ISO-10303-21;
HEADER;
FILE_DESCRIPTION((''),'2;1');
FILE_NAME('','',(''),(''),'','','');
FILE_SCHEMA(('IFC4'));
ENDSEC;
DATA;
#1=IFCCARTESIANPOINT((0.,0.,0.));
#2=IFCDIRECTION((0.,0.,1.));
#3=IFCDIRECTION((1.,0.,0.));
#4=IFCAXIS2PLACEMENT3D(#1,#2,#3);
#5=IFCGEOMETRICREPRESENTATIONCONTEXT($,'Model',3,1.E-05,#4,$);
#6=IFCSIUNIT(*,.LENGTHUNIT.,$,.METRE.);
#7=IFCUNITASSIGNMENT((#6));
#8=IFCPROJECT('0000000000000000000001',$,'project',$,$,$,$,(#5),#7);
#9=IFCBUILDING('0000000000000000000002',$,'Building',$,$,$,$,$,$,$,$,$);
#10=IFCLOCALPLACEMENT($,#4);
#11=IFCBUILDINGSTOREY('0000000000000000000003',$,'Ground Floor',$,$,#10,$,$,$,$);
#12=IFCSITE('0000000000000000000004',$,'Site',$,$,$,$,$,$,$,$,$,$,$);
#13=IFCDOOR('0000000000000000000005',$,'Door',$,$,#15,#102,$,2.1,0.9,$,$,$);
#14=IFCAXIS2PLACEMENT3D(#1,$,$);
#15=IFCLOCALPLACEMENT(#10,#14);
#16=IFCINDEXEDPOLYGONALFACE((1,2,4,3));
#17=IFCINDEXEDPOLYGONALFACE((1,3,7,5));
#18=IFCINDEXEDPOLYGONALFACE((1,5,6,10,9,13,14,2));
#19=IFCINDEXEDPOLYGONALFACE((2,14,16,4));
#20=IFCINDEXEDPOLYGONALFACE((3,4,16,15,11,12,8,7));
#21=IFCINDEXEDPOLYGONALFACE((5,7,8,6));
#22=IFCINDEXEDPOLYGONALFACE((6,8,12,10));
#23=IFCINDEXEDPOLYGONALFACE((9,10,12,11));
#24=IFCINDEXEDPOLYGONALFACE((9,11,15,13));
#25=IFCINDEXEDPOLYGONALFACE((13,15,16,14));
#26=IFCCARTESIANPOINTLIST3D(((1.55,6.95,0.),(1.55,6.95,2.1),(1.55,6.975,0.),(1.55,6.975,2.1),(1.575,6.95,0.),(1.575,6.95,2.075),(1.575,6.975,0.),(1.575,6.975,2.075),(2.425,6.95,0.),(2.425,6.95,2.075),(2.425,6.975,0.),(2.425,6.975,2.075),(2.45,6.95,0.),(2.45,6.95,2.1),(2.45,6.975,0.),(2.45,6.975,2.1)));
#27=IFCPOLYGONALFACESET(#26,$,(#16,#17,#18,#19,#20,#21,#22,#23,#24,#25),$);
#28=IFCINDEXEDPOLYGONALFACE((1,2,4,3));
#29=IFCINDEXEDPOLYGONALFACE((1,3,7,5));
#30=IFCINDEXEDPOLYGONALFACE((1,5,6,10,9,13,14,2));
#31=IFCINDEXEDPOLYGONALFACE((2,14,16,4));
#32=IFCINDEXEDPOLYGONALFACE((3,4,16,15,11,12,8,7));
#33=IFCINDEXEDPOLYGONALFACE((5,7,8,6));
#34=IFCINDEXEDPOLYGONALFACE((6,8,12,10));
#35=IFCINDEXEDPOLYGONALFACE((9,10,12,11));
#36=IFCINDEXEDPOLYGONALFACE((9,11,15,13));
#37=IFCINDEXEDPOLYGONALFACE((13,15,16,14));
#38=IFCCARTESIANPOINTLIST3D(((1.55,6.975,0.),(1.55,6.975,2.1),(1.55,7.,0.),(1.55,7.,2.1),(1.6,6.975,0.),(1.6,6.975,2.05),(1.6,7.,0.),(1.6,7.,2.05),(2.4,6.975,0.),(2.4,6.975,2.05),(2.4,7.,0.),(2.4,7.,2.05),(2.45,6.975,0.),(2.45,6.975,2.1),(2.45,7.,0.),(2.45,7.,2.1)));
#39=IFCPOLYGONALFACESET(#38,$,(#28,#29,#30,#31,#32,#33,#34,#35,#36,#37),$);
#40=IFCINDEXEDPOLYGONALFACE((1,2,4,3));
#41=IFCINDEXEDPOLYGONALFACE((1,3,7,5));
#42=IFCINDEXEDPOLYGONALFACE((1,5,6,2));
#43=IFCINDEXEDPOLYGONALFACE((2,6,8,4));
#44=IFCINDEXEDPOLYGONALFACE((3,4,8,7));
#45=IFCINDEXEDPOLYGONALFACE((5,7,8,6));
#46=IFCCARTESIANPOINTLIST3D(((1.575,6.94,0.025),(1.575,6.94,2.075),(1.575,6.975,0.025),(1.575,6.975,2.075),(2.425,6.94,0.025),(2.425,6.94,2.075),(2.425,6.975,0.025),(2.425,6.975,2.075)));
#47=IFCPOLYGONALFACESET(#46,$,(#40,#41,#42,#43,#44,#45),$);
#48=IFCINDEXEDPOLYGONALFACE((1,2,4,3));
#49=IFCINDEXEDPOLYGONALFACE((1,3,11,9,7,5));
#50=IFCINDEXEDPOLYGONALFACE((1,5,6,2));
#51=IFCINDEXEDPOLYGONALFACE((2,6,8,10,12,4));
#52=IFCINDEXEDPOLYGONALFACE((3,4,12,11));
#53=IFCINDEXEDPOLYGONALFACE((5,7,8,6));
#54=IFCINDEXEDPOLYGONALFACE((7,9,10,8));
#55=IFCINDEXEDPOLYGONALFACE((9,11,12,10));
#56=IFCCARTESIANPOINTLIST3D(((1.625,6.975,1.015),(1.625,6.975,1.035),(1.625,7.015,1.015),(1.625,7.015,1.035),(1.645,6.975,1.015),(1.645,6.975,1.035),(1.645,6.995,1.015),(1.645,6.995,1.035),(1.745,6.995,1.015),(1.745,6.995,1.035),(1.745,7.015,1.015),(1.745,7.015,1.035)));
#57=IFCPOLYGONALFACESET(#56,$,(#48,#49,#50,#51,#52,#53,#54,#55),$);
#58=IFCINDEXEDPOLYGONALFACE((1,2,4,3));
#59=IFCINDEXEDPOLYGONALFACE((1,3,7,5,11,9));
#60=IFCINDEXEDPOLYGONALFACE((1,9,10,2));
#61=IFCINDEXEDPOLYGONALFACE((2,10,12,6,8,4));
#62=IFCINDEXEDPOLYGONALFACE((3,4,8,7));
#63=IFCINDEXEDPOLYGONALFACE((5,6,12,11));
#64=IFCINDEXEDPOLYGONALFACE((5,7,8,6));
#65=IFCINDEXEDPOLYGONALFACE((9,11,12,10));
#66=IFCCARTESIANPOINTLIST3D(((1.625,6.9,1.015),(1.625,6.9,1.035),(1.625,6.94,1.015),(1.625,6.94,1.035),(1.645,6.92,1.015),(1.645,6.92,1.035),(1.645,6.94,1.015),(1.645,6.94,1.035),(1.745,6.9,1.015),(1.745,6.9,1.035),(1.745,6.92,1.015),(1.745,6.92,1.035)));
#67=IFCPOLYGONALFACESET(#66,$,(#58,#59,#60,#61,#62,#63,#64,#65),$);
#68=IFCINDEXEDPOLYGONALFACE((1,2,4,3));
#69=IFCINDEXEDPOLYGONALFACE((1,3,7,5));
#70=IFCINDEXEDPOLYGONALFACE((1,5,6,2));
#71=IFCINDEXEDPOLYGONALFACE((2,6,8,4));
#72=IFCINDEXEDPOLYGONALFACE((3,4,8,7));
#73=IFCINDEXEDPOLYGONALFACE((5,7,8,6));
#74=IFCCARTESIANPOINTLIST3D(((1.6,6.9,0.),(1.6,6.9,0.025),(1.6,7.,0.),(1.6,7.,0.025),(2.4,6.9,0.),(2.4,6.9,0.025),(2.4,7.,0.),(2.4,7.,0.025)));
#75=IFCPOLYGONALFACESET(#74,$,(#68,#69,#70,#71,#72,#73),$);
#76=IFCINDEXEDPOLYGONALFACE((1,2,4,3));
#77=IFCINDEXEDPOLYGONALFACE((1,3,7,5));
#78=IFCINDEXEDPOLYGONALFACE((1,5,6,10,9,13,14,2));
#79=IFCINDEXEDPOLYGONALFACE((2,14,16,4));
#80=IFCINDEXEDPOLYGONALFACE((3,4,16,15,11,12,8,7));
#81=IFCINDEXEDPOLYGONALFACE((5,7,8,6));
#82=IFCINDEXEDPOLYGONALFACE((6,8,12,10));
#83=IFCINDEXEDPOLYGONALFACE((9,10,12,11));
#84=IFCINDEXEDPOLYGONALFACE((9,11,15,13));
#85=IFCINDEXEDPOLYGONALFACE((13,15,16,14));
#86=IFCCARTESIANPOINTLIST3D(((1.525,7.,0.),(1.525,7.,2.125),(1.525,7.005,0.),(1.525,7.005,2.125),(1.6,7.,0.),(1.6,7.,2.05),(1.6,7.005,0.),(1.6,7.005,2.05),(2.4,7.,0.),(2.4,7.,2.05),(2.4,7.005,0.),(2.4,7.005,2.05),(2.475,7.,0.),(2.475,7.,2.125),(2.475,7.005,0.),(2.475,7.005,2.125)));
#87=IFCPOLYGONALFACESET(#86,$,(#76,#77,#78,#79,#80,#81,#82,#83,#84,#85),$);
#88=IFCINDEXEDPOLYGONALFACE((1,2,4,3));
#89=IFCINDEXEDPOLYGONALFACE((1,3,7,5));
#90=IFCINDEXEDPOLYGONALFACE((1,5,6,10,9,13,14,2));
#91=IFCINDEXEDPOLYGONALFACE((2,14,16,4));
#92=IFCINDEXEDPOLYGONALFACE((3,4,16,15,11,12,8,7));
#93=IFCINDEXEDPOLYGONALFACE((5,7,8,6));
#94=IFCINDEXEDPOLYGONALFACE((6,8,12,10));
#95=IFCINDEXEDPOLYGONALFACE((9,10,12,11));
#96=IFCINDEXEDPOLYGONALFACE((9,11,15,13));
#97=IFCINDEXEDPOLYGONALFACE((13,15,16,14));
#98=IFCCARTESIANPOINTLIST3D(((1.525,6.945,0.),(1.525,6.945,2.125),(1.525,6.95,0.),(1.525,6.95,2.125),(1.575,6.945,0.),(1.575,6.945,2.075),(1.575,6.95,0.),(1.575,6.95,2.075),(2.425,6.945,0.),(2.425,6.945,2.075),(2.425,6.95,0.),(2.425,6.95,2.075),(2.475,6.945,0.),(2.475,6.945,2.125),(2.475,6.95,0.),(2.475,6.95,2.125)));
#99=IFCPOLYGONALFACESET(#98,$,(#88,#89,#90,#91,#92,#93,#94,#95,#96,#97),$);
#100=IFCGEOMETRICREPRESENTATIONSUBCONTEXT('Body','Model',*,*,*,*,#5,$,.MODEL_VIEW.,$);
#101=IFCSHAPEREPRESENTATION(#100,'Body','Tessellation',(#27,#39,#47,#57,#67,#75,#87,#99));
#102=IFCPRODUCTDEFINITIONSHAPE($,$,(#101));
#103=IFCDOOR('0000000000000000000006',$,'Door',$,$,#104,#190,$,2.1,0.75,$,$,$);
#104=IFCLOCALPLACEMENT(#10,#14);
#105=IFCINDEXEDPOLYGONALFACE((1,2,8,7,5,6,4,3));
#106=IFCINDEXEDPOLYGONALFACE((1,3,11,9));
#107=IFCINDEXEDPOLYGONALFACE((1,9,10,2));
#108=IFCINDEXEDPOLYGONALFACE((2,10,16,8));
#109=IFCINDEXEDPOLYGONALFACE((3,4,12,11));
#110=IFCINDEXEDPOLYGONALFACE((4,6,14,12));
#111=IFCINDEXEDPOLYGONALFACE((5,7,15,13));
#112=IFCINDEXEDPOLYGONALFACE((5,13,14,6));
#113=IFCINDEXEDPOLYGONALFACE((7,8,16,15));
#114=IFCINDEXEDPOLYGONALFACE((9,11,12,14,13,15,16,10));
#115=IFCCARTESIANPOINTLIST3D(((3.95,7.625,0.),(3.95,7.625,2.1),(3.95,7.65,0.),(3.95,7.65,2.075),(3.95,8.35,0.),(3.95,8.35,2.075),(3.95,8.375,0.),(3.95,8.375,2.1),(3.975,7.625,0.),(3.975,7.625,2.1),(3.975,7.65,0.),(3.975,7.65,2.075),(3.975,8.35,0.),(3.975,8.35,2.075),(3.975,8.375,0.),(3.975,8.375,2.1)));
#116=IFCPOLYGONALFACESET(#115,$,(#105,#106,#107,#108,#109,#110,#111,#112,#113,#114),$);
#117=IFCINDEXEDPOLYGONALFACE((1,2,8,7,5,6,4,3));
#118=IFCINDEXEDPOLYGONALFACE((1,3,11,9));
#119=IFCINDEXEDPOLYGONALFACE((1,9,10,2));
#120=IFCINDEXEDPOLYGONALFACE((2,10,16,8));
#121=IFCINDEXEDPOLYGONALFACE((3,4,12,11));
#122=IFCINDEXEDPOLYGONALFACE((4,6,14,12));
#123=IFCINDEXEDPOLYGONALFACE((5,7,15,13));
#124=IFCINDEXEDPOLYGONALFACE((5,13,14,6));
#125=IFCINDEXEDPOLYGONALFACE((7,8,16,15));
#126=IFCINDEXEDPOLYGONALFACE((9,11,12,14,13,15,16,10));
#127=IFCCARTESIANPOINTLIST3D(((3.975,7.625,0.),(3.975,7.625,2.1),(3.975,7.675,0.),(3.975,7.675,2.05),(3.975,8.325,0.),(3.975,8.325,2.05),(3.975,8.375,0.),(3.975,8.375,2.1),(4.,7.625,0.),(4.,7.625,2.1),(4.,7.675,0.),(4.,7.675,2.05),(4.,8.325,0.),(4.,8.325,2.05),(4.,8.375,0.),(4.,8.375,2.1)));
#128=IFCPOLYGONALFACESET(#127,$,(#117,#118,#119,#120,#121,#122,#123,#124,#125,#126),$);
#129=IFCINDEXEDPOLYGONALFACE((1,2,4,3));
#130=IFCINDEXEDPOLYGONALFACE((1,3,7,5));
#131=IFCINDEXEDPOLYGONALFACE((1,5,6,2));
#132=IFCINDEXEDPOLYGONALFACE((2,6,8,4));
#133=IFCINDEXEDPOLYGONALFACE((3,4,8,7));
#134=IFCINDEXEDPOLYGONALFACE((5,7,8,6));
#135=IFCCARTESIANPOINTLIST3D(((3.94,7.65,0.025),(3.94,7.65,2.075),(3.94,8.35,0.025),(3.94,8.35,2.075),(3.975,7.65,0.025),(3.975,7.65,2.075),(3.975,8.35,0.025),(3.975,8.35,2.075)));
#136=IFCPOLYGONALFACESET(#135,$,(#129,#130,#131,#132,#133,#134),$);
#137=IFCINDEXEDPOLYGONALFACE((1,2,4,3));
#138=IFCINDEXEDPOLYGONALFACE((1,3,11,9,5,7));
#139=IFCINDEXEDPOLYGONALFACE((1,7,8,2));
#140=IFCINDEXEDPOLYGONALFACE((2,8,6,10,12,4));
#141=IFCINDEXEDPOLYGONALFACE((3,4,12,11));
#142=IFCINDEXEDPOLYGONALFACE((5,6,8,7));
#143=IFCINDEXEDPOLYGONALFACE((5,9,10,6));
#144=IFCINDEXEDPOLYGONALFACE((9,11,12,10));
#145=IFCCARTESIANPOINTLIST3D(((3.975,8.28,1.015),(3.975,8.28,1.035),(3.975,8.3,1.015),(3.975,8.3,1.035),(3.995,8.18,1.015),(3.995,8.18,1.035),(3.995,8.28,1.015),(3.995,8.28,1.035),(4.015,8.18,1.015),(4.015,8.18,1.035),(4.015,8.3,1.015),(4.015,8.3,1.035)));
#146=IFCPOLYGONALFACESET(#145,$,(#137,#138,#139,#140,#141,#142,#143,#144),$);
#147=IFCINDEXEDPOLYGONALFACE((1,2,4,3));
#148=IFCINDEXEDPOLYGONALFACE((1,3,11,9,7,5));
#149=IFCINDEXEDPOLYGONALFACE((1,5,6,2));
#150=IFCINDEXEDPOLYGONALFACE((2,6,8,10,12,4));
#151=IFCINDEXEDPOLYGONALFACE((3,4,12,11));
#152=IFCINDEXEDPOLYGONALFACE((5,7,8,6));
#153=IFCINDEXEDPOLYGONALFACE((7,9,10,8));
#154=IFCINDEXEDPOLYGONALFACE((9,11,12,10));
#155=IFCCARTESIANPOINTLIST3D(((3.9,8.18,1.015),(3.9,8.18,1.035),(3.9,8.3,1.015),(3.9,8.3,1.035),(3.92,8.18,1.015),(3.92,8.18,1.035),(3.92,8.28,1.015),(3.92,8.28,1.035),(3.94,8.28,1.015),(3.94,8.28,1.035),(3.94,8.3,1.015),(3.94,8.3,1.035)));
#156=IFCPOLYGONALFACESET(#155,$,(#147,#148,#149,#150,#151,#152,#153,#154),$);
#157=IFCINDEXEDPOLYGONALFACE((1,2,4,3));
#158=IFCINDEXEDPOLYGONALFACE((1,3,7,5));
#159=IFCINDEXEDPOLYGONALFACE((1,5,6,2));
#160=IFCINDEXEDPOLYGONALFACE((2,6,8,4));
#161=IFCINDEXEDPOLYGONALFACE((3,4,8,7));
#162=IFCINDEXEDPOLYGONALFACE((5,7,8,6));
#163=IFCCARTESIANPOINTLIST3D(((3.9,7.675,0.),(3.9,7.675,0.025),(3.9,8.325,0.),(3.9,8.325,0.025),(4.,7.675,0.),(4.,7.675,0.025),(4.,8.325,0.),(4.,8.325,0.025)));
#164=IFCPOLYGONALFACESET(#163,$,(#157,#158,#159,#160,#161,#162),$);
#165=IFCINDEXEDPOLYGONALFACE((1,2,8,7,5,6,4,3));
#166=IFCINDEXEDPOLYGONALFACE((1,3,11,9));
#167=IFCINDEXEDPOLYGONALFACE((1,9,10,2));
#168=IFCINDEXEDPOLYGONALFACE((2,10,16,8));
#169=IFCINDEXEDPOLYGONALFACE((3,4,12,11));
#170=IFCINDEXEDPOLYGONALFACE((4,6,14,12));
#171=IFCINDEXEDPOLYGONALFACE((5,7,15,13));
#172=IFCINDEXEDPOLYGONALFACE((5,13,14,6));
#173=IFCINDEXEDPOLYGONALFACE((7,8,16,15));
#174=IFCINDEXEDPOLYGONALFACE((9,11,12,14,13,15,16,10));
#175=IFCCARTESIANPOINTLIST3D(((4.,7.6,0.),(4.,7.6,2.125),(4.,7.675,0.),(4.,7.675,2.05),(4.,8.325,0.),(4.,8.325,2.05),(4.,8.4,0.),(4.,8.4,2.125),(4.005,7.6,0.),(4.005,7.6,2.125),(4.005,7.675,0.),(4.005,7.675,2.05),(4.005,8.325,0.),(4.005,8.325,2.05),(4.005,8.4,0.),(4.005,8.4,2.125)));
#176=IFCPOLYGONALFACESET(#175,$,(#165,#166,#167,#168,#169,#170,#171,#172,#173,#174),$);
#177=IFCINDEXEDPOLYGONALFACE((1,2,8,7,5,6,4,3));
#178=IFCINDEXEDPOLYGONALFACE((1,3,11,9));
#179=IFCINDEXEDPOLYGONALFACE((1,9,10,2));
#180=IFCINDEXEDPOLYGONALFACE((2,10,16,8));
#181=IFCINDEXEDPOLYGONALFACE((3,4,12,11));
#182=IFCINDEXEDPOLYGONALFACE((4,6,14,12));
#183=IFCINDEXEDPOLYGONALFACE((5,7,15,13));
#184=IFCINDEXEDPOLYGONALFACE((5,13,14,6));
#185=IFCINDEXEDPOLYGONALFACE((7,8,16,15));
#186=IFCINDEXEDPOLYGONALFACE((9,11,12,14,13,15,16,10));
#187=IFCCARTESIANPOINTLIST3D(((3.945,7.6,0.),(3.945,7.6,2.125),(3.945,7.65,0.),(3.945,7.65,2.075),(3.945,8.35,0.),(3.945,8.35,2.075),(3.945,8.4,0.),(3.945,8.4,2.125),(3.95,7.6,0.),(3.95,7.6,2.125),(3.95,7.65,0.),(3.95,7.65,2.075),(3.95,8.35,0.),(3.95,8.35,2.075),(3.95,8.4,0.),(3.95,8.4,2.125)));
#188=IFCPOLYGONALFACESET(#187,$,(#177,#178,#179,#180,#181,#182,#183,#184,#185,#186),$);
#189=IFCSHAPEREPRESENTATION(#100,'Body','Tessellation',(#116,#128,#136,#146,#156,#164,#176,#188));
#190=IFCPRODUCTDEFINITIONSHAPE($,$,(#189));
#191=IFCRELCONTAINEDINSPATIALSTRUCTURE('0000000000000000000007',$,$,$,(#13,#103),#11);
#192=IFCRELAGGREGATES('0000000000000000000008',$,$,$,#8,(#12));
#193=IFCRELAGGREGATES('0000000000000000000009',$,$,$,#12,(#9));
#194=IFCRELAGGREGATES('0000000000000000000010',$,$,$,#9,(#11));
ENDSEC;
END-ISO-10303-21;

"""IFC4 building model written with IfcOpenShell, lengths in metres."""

from ifc_helpers import new_model, si_unit, frame, origin_with_axes, place, context, subcontext, project, spatial, line, indexed_curve, outline, extrude, element, save


model = new_model("IFC4")

# Units and contexts
model_context = context("Model", 3, precision=1e-05, world=origin_with_axes())
body_context = subcontext(model_context, "Body", "Model", "MODEL_VIEW")
ifc_project = project(units=[si_unit("LENGTHUNIT", "METRE")], contexts=[model_context])

# Site, building, storey
site = spatial("IfcSite", under=ifc_project, Name="Site")
building = spatial("IfcBuilding", under=site, Name="Building")
storey_placement = place(None, origin_with_axes())
storey = spatial("IfcBuildingStorey", under=building, at=storey_placement, Name="Ground Floor")

# Doors
door_1_placement = place(storey_placement, frame((2.45, 7.0, 0.0), z_axis=(0.0, 0.0, 1.0), x_axis=(-1.0, 0.0, 0.0)))
element("IfcDoor", 1, at=door_1_placement, inside=storey, Name="Door", OverallHeight=2.1, OverallWidth=0.9, context=body_context, shape_type="SweptSolid", body=[
    extrude(outline(indexed_curve([(0.0, 0.0), (0.0, 2.1), (0.9, 2.1), (0.9, 0.0), (0.875, 0.0), (0.875, 2.075), (0.025, 2.075), (0.025, 0.0)], segments=[line(1, 2, 3, 4, 5, 6, 7, 8, 1)])), frame((0.0, 0.025, 0.0), z_axis=(0.0, -1.0, 0.0), x_axis=(1.0, 0.0, 0.0)), (0.0, 0.0, -1.0), 0.025),
    extrude(outline(indexed_curve([(0.0, 0.0), (0.0, 2.1), (0.9, 2.1), (0.9, 0.0), (0.85, 0.0), (0.85, 2.05), (0.05, 2.05), (0.05, 0.0)], segments=[line(1, 2, 3, 4, 5, 6, 7, 8, 1)])), frame((0.0, 0.0, 0.0), z_axis=(0.0, -1.0, 0.0), x_axis=(1.0, 0.0, 0.0)), (0.0, 0.0, -1.0), 0.025),
    extrude(outline(indexed_curve([(0.0, 0.0), (0.85, 0.0), (0.85, 0.035), (0.0, 0.035)], segments=[line(1, 2, 3, 4, 1)])), frame((0.025, 0.025, 0.025), z_axis=(0.0, 0.0, 1.0), x_axis=(1.0, 0.0, 0.0)), (0.0, 0.0, 1.0), 2.05),
    extrude(outline(indexed_curve([(0.0, 0.0), (0.0, -0.04), (-0.12, -0.04), (-0.12, -0.02), (-0.02, -0.02), (-0.02, 0.0)], segments=[line(1, 2, 3, 4, 5, 6, 1)])), frame((0.825, 0.025, 1.015), z_axis=(0.0, 0.0, 1.0), x_axis=(1.0, 0.0, 0.0)), (0.0, 0.0, 1.0), 0.02),
    extrude(outline(indexed_curve([(0.0, 0.0), (0.0, 0.04), (-0.12, 0.04), (-0.12, 0.02), (-0.02, 0.02), (-0.02, 0.0)], segments=[line(1, 2, 3, 4, 5, 6, 1)])), frame((0.825, 0.06, 1.015), z_axis=(0.0, 0.0, 1.0), x_axis=(1.0, 0.0, 0.0)), (0.0, 0.0, 1.0), 0.02),
    extrude(outline(indexed_curve([(0.0, 0.0), (0.8, 0.0), (0.8, 0.1), (0.0, 0.1)], segments=[line(1, 2, 3, 4, 1)])), frame((0.05, 0.0, 0.0), z_axis=(0.0, 0.0, 1.0), x_axis=(1.0, 0.0, 0.0)), (0.0, 0.0, 1.0), 0.025),
    extrude(outline(indexed_curve([(0.0, 0.0), (0.0, 2.125), (0.95, 2.125), (0.95, 0.0), (0.875, 0.0), (0.875, 2.05), (0.075, 2.05), (0.075, 0.0)], segments=[line(1, 2, 3, 4, 5, 6, 7, 8, 1)])), frame((-0.025, -0.005, 0.0), z_axis=(0.0, -1.0, 0.0), x_axis=(1.0, 0.0, 0.0)), (0.0, 0.0, -1.0), 0.005),
    extrude(outline(indexed_curve([(0.0, 0.0), (0.0, 2.125), (0.95, 2.125), (0.95, 0.0), (0.9, 0.0), (0.9, 2.075), (0.05, 2.075), (0.05, 0.0)], segments=[line(1, 2, 3, 4, 5, 6, 7, 8, 1)])), frame((-0.025, 0.05, 0.0), z_axis=(0.0, -1.0, 0.0), x_axis=(1.0, 0.0, 0.0)), (0.0, 0.0, -1.0), 0.005),
])
door_2_placement = place(storey_placement, frame((4.0, 7.625, 0.0), z_axis=(0.0, 0.0, 1.0), x_axis=(0.0, 1.0, 0.0)))
element("IfcDoor", 2, at=door_2_placement, inside=storey, Name="Door", OverallHeight=2.1, OverallWidth=0.75, context=body_context, shape_type="SweptSolid", body=[
    extrude(outline(indexed_curve([(0.0, 0.0), (0.0, 2.1), (0.75, 2.1), (0.75, 0.0), (0.725, 0.0), (0.725, 2.075), (0.025, 2.075), (0.025, 0.0)], segments=[line(1, 2, 3, 4, 5, 6, 7, 8, 1)])), frame((0.0, 0.025, 0.0), z_axis=(0.0, -1.0, 0.0), x_axis=(1.0, 0.0, 0.0)), (0.0, 0.0, -1.0), 0.025),
    extrude(outline(indexed_curve([(0.0, 0.0), (0.0, 2.1), (0.75, 2.1), (0.75, 0.0), (0.7, 0.0), (0.7, 2.05), (0.05, 2.05), (0.05, 0.0)], segments=[line(1, 2, 3, 4, 5, 6, 7, 8, 1)])), frame((0.0, 0.0, 0.0), z_axis=(0.0, -1.0, 0.0), x_axis=(1.0, 0.0, 0.0)), (0.0, 0.0, -1.0), 0.025),
    extrude(outline(indexed_curve([(0.0, 0.0), (0.7, 0.0), (0.7, 0.035), (0.0, 0.035)], segments=[line(1, 2, 3, 4, 1)])), frame((0.025, 0.025, 0.025), z_axis=(0.0, 0.0, 1.0), x_axis=(1.0, 0.0, 0.0)), (0.0, 0.0, 1.0), 2.05),
    extrude(outline(indexed_curve([(0.0, 0.0), (0.0, -0.04), (-0.12, -0.04), (-0.12, -0.02), (-0.02, -0.02), (-0.02, 0.0)], segments=[line(1, 2, 3, 4, 5, 6, 1)])), frame((0.675, 0.025, 1.015), z_axis=(0.0, 0.0, 1.0), x_axis=(1.0, 0.0, 0.0)), (0.0, 0.0, 1.0), 0.02),
    extrude(outline(indexed_curve([(0.0, 0.0), (0.0, 0.04), (-0.12, 0.04), (-0.12, 0.02), (-0.02, 0.02), (-0.02, 0.0)], segments=[line(1, 2, 3, 4, 5, 6, 1)])), frame((0.675, 0.06, 1.015), z_axis=(0.0, 0.0, 1.0), x_axis=(1.0, 0.0, 0.0)), (0.0, 0.0, 1.0), 0.02),
    extrude(outline(indexed_curve([(0.0, 0.0), (0.65, 0.0), (0.65, 0.1), (0.0, 0.1)], segments=[line(1, 2, 3, 4, 1)])), frame((0.05, 0.0, 0.0), z_axis=(0.0, 0.0, 1.0), x_axis=(1.0, 0.0, 0.0)), (0.0, 0.0, 1.0), 0.025),
    extrude(outline(indexed_curve([(0.0, 0.0), (0.0, 2.125), (0.8, 2.125), (0.8, 0.0), (0.725, 0.0), (0.725, 2.05), (0.075, 2.05), (0.075, 0.0)], segments=[line(1, 2, 3, 4, 5, 6, 7, 8, 1)])), frame((-0.025, -0.005, 0.0), z_axis=(0.0, -1.0, 0.0), x_axis=(1.0, 0.0, 0.0)), (0.0, 0.0, -1.0), 0.005),
    extrude(outline(indexed_curve([(0.0, 0.0), (0.0, 2.125), (0.8, 2.125), (0.8, 0.0), (0.75, 0.0), (0.75, 2.075), (0.05, 2.075), (0.05, 0.0)], segments=[line(1, 2, 3, 4, 5, 6, 7, 8, 1)])), frame((-0.025, 0.05, 0.0), z_axis=(0.0, -1.0, 0.0), x_axis=(1.0, 0.0, 0.0)), (0.0, 0.0, -1.0), 0.005),
])

save(model, "model.ifc")
